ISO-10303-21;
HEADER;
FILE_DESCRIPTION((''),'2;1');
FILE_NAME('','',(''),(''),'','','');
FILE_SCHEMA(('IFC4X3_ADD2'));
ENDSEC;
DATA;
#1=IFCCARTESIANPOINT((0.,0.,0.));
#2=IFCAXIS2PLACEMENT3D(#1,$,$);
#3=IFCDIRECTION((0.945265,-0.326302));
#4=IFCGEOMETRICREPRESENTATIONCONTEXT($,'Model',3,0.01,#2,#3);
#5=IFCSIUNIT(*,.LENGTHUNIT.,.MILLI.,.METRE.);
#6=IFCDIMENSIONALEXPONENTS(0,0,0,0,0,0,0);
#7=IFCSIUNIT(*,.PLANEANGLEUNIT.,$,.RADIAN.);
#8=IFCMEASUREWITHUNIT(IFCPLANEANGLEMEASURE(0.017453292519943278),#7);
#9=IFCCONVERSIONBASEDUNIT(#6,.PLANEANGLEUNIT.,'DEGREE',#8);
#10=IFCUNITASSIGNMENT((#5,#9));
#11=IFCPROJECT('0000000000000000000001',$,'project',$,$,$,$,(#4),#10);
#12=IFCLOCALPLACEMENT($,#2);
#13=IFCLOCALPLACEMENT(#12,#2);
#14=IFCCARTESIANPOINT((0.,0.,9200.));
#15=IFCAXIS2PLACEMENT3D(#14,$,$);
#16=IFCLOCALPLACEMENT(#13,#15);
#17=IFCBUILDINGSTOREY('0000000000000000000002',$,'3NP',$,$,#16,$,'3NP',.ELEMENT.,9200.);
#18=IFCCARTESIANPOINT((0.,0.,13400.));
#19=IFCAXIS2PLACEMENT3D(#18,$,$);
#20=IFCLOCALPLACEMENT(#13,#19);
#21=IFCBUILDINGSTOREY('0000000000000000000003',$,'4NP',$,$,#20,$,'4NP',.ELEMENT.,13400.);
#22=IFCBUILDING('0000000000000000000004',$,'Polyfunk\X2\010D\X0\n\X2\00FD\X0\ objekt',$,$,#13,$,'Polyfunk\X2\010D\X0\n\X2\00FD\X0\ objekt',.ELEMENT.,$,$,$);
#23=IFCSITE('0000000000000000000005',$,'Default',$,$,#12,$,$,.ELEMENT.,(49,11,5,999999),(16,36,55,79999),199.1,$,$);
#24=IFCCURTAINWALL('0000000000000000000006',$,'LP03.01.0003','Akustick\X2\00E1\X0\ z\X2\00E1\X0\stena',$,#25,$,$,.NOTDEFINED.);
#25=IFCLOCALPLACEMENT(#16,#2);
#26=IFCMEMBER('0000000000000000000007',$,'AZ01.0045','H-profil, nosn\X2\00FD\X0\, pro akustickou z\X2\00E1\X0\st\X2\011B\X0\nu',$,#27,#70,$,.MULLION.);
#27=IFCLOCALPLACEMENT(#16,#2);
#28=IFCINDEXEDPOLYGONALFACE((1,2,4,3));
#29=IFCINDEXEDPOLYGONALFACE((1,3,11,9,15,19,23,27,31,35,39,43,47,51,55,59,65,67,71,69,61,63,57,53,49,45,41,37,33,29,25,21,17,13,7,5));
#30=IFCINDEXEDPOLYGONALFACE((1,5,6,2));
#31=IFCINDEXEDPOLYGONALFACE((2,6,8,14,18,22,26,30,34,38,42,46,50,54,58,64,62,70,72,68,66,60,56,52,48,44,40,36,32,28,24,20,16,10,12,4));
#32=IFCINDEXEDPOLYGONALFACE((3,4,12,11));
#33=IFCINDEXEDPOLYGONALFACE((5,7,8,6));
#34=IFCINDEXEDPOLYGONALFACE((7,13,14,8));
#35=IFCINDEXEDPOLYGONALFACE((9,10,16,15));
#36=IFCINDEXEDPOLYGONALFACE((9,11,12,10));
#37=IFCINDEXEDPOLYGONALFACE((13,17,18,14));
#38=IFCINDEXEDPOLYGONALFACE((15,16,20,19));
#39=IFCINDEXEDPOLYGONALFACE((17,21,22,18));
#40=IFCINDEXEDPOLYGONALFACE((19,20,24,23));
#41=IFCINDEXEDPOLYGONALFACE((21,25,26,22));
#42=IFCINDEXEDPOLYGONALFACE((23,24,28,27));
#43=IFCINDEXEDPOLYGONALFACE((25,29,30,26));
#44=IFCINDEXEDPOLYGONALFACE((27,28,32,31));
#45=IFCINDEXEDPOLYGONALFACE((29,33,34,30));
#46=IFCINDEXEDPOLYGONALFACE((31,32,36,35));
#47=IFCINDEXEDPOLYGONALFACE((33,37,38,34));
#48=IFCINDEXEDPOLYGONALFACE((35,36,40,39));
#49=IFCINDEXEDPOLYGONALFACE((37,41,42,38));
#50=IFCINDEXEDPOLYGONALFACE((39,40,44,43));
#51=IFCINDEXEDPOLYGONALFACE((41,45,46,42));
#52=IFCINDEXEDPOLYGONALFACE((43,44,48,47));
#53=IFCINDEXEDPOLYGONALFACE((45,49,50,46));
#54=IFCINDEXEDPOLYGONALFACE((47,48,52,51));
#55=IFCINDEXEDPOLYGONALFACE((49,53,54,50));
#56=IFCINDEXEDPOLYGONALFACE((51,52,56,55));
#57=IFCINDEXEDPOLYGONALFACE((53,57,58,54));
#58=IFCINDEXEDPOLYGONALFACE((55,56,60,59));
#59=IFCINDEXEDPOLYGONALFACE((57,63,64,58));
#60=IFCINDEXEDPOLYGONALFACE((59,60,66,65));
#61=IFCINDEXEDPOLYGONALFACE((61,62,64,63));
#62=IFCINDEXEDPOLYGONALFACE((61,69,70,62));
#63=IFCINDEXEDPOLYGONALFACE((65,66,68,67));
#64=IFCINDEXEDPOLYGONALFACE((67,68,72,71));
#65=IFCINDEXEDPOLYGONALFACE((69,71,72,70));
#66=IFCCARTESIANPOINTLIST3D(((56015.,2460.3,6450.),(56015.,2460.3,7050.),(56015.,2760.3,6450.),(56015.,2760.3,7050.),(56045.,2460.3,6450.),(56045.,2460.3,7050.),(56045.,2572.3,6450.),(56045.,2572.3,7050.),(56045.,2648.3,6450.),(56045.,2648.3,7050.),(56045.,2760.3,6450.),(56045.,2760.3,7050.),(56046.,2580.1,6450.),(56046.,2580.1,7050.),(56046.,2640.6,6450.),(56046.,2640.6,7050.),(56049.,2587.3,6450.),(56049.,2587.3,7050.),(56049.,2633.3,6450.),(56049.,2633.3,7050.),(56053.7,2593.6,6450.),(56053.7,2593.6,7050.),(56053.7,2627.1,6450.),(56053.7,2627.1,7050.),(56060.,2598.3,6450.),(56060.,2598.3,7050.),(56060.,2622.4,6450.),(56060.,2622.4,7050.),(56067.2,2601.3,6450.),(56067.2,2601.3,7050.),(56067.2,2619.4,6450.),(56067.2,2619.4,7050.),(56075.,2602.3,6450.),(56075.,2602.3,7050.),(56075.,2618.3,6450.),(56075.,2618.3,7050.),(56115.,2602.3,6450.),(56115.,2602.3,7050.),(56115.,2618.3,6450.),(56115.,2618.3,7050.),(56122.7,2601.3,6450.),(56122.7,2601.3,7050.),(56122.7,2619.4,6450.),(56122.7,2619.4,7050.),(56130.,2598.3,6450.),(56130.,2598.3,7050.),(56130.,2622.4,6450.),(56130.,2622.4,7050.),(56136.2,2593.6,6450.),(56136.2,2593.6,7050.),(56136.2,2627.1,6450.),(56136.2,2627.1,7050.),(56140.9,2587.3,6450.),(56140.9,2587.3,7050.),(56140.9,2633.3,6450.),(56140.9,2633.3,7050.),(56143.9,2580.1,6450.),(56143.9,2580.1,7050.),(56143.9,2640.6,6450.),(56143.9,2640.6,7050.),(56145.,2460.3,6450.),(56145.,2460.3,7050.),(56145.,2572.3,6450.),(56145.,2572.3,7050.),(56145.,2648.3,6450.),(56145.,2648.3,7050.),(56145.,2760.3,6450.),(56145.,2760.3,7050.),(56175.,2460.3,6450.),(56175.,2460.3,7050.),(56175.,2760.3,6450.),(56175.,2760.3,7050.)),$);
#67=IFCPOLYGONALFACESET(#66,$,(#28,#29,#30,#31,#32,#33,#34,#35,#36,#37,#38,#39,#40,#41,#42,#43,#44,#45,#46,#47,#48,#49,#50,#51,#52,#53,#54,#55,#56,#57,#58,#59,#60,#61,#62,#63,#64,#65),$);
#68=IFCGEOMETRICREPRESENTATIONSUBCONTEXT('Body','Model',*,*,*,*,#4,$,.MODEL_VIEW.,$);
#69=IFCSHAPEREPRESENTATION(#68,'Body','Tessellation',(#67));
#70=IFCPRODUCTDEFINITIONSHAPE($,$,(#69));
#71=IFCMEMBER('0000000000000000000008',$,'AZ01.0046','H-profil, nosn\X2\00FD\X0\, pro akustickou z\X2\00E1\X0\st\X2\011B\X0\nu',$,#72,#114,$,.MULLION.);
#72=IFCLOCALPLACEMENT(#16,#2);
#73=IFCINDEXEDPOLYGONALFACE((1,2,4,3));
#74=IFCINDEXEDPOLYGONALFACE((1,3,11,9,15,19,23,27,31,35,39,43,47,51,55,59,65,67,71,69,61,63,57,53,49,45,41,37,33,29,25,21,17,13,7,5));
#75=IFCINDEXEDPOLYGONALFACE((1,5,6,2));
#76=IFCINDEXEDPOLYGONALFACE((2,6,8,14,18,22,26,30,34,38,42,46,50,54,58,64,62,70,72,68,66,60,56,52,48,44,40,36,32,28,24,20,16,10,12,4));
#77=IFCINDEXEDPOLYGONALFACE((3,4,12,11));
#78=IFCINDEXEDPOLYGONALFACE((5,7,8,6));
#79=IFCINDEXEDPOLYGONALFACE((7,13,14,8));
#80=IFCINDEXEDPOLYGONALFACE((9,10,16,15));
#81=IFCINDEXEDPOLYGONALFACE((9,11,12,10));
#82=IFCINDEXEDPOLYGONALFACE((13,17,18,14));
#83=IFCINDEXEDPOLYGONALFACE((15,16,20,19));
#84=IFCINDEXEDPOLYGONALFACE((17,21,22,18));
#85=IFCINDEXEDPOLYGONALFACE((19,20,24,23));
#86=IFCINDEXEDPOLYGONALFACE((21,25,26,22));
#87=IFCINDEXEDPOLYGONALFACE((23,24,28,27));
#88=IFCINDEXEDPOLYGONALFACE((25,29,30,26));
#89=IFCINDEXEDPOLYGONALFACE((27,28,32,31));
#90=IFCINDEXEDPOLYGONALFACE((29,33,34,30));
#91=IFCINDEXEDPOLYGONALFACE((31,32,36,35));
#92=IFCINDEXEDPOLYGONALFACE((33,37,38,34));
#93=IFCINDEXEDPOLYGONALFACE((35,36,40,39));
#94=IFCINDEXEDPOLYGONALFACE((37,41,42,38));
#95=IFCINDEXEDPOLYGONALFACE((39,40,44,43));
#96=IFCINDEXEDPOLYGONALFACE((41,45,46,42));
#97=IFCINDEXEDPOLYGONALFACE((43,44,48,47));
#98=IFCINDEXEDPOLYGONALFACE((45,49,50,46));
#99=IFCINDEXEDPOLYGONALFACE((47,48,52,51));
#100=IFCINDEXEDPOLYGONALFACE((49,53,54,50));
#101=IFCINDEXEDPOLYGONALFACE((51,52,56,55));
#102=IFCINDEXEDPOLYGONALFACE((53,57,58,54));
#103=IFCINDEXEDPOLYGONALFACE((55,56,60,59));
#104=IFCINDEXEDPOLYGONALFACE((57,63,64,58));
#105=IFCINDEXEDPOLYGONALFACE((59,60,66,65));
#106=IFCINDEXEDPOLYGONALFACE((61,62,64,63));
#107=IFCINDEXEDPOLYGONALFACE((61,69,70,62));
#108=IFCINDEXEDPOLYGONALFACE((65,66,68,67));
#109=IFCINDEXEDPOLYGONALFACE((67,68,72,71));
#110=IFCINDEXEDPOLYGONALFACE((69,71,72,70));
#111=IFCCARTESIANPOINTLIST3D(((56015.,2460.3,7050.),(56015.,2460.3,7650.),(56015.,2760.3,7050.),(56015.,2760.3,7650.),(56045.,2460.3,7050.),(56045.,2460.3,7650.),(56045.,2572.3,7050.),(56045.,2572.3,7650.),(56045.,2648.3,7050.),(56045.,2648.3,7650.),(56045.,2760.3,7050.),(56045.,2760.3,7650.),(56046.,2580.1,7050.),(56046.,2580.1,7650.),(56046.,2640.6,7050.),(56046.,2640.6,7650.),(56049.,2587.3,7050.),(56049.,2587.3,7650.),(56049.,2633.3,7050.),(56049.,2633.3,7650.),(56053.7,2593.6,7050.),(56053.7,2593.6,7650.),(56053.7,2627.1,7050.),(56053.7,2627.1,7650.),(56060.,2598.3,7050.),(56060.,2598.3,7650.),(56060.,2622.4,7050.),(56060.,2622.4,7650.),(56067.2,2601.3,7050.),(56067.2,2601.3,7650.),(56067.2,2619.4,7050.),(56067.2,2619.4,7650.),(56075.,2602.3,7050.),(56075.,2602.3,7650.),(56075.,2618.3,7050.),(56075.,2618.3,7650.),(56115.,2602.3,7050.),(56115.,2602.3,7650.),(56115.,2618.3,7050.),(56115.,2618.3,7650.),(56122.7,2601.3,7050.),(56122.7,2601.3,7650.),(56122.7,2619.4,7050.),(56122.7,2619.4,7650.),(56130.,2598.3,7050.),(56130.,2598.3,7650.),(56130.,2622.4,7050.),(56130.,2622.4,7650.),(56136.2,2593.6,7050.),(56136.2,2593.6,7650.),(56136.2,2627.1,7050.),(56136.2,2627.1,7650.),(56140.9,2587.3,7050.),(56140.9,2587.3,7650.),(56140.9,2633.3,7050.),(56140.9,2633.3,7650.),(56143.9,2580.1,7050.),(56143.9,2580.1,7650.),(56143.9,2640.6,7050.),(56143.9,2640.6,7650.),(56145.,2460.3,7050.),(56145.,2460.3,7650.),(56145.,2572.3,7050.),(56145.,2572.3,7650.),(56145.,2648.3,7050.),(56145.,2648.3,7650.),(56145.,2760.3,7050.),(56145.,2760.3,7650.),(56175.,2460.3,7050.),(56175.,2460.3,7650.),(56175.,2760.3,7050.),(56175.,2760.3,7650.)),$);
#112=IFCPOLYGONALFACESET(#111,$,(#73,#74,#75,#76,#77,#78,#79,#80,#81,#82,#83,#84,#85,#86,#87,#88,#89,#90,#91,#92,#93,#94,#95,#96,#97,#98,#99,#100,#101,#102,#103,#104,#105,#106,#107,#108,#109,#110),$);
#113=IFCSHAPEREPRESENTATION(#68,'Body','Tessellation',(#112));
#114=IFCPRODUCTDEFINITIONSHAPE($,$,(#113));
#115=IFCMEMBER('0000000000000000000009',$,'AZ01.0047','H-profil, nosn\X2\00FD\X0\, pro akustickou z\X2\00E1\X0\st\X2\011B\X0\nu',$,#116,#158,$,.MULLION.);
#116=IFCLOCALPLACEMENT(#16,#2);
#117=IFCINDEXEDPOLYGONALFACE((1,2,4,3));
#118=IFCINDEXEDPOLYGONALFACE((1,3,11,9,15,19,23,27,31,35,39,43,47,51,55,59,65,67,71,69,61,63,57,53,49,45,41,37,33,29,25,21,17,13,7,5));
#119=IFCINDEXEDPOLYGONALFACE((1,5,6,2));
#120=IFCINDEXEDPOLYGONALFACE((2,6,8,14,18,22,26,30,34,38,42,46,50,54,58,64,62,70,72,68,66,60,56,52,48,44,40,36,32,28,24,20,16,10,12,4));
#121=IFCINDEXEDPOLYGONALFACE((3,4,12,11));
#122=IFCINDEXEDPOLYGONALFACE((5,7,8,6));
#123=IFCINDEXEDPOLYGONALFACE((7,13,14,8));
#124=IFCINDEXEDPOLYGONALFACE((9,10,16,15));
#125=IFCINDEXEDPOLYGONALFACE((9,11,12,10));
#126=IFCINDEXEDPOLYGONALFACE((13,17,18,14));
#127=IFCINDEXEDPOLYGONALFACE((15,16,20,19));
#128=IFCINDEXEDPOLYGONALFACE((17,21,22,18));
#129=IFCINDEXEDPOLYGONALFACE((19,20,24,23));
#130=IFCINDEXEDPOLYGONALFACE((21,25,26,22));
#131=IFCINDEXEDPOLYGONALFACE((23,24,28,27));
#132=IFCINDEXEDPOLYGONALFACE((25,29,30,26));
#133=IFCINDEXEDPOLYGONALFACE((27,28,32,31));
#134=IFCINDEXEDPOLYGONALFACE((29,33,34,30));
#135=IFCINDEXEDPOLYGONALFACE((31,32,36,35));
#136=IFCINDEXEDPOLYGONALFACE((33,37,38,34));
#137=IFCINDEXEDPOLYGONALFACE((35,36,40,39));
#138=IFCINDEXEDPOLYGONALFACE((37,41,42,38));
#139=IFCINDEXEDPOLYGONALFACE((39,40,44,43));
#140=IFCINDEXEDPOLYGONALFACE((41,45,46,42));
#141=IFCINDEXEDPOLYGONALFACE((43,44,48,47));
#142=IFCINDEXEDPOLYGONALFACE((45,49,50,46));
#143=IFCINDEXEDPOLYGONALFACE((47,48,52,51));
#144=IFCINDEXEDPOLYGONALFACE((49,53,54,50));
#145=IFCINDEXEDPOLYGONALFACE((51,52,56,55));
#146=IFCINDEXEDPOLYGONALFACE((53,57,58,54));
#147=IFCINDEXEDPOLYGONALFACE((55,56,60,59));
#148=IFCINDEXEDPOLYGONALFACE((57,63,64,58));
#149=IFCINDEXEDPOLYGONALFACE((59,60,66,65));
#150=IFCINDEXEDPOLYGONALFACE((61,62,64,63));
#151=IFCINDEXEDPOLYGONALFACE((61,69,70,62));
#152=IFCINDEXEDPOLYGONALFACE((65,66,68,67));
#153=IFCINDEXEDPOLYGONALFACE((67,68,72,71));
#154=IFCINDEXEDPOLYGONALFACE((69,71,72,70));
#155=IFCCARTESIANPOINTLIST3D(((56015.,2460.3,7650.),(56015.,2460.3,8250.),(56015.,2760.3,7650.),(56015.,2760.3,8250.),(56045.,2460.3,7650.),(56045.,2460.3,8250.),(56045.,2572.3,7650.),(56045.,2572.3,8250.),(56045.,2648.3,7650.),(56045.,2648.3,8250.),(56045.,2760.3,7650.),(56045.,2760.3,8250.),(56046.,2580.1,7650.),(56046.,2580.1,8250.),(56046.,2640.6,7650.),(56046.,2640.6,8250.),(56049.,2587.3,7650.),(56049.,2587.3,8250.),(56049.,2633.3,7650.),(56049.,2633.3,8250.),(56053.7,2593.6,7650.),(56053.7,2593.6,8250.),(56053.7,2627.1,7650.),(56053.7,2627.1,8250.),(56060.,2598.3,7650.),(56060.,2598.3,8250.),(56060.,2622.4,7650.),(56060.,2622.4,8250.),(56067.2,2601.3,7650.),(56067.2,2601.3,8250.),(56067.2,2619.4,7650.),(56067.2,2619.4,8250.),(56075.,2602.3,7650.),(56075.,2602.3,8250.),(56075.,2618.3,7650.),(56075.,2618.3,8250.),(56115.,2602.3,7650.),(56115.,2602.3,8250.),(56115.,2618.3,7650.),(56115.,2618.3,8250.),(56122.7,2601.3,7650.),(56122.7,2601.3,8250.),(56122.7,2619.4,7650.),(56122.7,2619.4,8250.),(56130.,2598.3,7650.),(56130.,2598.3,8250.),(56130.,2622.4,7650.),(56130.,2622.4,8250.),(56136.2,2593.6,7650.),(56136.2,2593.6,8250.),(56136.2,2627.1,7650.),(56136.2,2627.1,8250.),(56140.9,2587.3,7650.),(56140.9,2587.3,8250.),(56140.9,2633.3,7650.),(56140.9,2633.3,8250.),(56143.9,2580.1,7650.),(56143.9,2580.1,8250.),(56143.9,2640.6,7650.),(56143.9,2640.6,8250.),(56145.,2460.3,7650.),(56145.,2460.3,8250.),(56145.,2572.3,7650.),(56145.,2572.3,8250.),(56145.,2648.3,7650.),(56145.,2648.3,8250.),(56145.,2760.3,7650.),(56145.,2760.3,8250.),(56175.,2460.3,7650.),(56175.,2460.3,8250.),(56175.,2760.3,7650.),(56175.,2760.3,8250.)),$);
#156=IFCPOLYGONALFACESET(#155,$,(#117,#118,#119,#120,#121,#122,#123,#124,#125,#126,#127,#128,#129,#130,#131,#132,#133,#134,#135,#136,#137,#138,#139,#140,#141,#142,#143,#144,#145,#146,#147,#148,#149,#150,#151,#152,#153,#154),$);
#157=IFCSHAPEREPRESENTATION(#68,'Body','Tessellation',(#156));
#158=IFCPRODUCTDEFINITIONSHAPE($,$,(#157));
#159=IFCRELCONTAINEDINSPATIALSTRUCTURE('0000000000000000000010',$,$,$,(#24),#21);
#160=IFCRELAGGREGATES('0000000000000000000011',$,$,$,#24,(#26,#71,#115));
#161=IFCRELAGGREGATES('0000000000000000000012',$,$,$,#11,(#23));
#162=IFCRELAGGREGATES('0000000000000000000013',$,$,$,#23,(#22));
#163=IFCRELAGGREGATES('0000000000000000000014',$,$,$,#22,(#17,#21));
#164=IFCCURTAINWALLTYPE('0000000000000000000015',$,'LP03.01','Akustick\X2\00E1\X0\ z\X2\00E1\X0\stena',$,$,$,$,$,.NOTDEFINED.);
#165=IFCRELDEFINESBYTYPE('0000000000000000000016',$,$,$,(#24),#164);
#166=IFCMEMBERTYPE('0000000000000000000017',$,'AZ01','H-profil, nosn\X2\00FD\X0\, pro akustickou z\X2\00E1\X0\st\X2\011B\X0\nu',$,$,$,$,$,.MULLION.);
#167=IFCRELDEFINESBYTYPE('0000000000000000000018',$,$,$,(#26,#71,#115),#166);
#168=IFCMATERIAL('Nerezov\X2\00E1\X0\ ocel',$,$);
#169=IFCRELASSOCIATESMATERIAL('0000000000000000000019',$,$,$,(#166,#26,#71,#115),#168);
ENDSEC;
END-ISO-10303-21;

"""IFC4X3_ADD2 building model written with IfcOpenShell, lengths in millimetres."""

from ifc_helpers import new_model, entity, si_unit, converted_unit, direction, frame, frame_2d, origin, place, context, subcontext, project, spatial, polyline, circle_curve, parameter, trimmed, segment, composite_curve, outline, extrude, source, transform, mapped, material, material_profile, profile_set, profile_usage, type_object, element, aggregate, save


model = new_model("IFC4X3_ADD2")

# Units and contexts
model_context = context("Model", 3, precision=0.01, world=origin(), true_north=direction((0.945265, -0.326302)))
body_context = subcontext(model_context, "Body", "Model", "MODEL_VIEW")
ifc_project = project(units=[si_unit("LENGTHUNIT", "METRE", prefix="MILLI"), converted_unit("PLANEANGLEUNIT", "DEGREE", entity("IfcPlaneAngleMeasure", 0.017453292519943278), si_unit("PLANEANGLEUNIT", "RADIAN"), dimensions=[0, 0, 0, 0, 0, 0, 0])], contexts=[model_context])

# Site, building, storey
site_placement = place(None, origin())
site = spatial("IfcSite", under=ifc_project, at=site_placement, Name="Default", CompositionType="ELEMENT", RefLatitude=(49, 11, 5, 999999), RefLongitude=(16, 36, 55, 79999), RefElevation=199.1)
building_placement = place(site_placement, origin())
building = spatial("IfcBuilding", under=site, at=building_placement, Name="Polyfunkčný objekt", LongName="Polyfunkčný objekt", CompositionType="ELEMENT")
storey_1_placement = place(building_placement, frame((0.0, 0.0, 9200.0)))
storey_1 = spatial("IfcBuildingStorey", under=building, at=storey_1_placement, Name="3NP", LongName="3NP", CompositionType="ELEMENT", Elevation=9200.0)

# Shared definitions
storey_2_placement = place(building_placement, frame((0.0, 0.0, 13400.0)))
storey_2 = spatial("IfcBuildingStorey", under=building, at=storey_2_placement, Name="4NP", LongName="4NP", CompositionType="ELEMENT", Elevation=13400.0)

# Shared definitions
curtain_wall_type_1 = type_object("IfcCurtainWallType", Name="LP03.01", Description="Akustická zástena", PredefinedType="NOTDEFINED")
ifc_material_1 = material(Name="Nerezová ocel")
ifc_material_profile_1 = material_profile(ifc_material_1, outline(composite_curve([segment(polyline([(50.0, -150.0), (80.0, -150.0)]), True, "CONTINUOUS"), segment(polyline([(80.0, -150.0), (80.0, 150.0)]), True, "CONTINUOUS"), segment(polyline([(80.0, 150.0), (50.0, 150.0)]), True, "CONTINUOUS"), segment(polyline([(50.0, 150.0), (50.0, 38.0)]), True, "CONTINUOUS"), segment(trimmed(circle_curve(frame_2d((20.0, 38.0), x_axis=(0.0, 1.0)), 30.0), [parameter(180.0)], [parameter(270.0)], True, "PARAMETER"), False, "CONTINUOUS"), segment(polyline([(20.0, 8.0), (-20.0, 8.0)]), True, "CONTINUOUS"), segment(trimmed(circle_curve(frame_2d((-20.0, 38.0), x_axis=(0.0, 1.0)), 30.0), [parameter(90.0)], [parameter(180.0)], True, "PARAMETER"), False, "CONTINUOUS"), segment(polyline([(-50.0, 38.0), (-50.0, 150.0)]), True, "CONTINUOUS"), segment(polyline([(-50.0, 150.0), (-80.0, 150.0)]), True, "CONTINUOUS"), segment(polyline([(-80.0, 150.0), (-80.0, -150.0)]), True, "CONTINUOUS"), segment(polyline([(-80.0, -150.0), (-50.0, -150.0)]), True, "CONTINUOUS"), segment(polyline([(-50.0, -150.0), (-50.0, -38.0)]), True, "CONTINUOUS"), segment(trimmed(circle_curve(frame_2d((-20.0, -38.0), x_axis=(0.0, 1.0)), 30.0), [parameter(0.0)], [parameter(90.0)], True, "PARAMETER"), False, "CONTINUOUS"), segment(polyline([(-20.0, -8.0), (20.0, -8.0)]), True, "CONTINUOUS"), segment(trimmed(circle_curve(frame_2d((20.0, -38.0), x_axis=(0.0, 1.0)), 30.0), [parameter(270.0)], [parameter(0.0)], True, "PARAMETER"), False, "CONTINUOUS"), segment(polyline([(50.0, -38.0), (50.0, -150.0)]), True, "CONTINUOUS")], self_intersect=False)), Name="Profil zástena")
ifc_profile_set_1 = profile_set([ifc_material_profile_1], Name="Profil zástena")
ifc_profile_usage_1 = profile_usage(ifc_profile_set_1)
member_type_1 = type_object("IfcMemberType", Name="AZ01", Description="H-profil, nosný, pro akustickou zástěnu", PredefinedType="MULLION", material=ifc_profile_set_1)

# Curtain wall, members
curtain_wall_1_placement = place(storey_2_placement, frame((0.0, 0.0, -13400.0)))
curtain_wall_1 = element("IfcCurtainWall", 1, at=curtain_wall_1_placement, inside=storey_2, type_object=curtain_wall_type_1, Name="LP03.01.0003", Description="Akustická zástena", PredefinedType="NOTDEFINED")
shared_shape_1 = source(origin(), body_context, "Body", "SweptSolid", [
    extrude(outline(composite_curve([segment(polyline([(-150.0, -50.0), (-150.0, -80.0)]), True, "CONTINUOUS"), segment(polyline([(-150.0, -80.0), (150.0, -80.0)]), True, "CONTINUOUS"), segment(polyline([(150.0, -80.0), (150.0, -50.0)]), True, "CONTINUOUS"), segment(polyline([(150.0, -50.0), (38.0, -50.0)]), True, "CONTINUOUS"), segment(trimmed(circle_curve(frame_2d((38.0, -20.0), x_axis=(1.0, 0.0)), 30.0), [parameter(180.0)], [parameter(270.0)], True, "PARAMETER"), False, "CONTINUOUS"), segment(polyline([(8.0, -20.0), (8.0, 20.0)]), True, "CONTINUOUS"), segment(trimmed(circle_curve(frame_2d((38.0, 20.0), x_axis=(1.0, 0.0)), 30.0), [parameter(90.0)], [parameter(180.0)], True, "PARAMETER"), False, "CONTINUOUS"), segment(polyline([(38.0, 50.0), (150.0, 50.0)]), True, "CONTINUOUS"), segment(polyline([(150.0, 50.0), (150.0, 80.0)]), True, "CONTINUOUS"), segment(polyline([(150.0, 80.0), (-150.0, 80.0)]), True, "CONTINUOUS"), segment(polyline([(-150.0, 80.0), (-150.0, 50.0)]), True, "CONTINUOUS"), segment(polyline([(-150.0, 50.0), (-38.0, 50.0)]), True, "CONTINUOUS"), segment(trimmed(circle_curve(frame_2d((-38.0, 20.0), x_axis=(1.0, 0.0)), 30.0), [parameter(0.0)], [parameter(90.0)], True, "PARAMETER"), False, "CONTINUOUS"), segment(polyline([(-8.0, 20.0), (-8.0, -20.0)]), True, "CONTINUOUS"), segment(trimmed(circle_curve(frame_2d((-38.0, -20.0), x_axis=(1.0, 0.0)), 30.0), [parameter(270.0)], [parameter(0.0)], True, "PARAMETER"), False, "CONTINUOUS"), segment(polyline([(-38.0, -50.0), (-150.0, -50.0)]), True, "CONTINUOUS")], self_intersect=False)), frame((0.0, 0.0, -600.0), z_axis=(0.0, 0.0, -1.0), x_axis=(1.0, 0.0, 0.0)), (0.0, 0.0, -1.0), 600.0),
])
member_1_placement = place(curtain_wall_1_placement, frame((56095.0, 2610.3, 15650.0), z_axis=(0.0, 0.0, -1.0), x_axis=(0.0, 1.0, 0.0)))
member_1 = element("IfcMember", 2, at=member_1_placement, type_object=member_type_1, material=ifc_profile_usage_1, Name="AZ01.0045", Description="H-profil, nosný, pro akustickou zástěnu", PredefinedType="MULLION", context=body_context, shape_type="MappedRepresentation", body=[
    mapped(shared_shape_1, transform((0.0, 0.0, 0.0), scale=1.0)),
])
member_2_placement = place(curtain_wall_1_placement, frame((56095.0, 2610.3, 16250.0), z_axis=(0.0, 0.0, -1.0), x_axis=(0.0, 1.0, 0.0)))
member_2 = element("IfcMember", 3, at=member_2_placement, type_object=member_type_1, material=ifc_profile_usage_1, Name="AZ01.0046", Description="H-profil, nosný, pro akustickou zástěnu", PredefinedType="MULLION", context=body_context, shape_type="MappedRepresentation", body=[
    mapped(shared_shape_1, transform((0.0, 0.0, 0.0), scale=1.0)),
])
member_3_placement = place(curtain_wall_1_placement, frame((56095.0, 2610.3, 16850.0), z_axis=(0.0, 0.0, -1.0), x_axis=(0.0, 1.0, 0.0)))
member_3 = element("IfcMember", 4, at=member_3_placement, type_object=member_type_1, material=ifc_profile_usage_1, Name="AZ01.0047", Description="H-profil, nosný, pro akustickou zástěnu", PredefinedType="MULLION", context=body_context, shape_type="MappedRepresentation", body=[
    mapped(shared_shape_1, transform((0.0, 0.0, 0.0), scale=1.0)),
])
aggregate(curtain_wall_1, [member_1, member_2, member_3])

save(model, "model.ifc")
